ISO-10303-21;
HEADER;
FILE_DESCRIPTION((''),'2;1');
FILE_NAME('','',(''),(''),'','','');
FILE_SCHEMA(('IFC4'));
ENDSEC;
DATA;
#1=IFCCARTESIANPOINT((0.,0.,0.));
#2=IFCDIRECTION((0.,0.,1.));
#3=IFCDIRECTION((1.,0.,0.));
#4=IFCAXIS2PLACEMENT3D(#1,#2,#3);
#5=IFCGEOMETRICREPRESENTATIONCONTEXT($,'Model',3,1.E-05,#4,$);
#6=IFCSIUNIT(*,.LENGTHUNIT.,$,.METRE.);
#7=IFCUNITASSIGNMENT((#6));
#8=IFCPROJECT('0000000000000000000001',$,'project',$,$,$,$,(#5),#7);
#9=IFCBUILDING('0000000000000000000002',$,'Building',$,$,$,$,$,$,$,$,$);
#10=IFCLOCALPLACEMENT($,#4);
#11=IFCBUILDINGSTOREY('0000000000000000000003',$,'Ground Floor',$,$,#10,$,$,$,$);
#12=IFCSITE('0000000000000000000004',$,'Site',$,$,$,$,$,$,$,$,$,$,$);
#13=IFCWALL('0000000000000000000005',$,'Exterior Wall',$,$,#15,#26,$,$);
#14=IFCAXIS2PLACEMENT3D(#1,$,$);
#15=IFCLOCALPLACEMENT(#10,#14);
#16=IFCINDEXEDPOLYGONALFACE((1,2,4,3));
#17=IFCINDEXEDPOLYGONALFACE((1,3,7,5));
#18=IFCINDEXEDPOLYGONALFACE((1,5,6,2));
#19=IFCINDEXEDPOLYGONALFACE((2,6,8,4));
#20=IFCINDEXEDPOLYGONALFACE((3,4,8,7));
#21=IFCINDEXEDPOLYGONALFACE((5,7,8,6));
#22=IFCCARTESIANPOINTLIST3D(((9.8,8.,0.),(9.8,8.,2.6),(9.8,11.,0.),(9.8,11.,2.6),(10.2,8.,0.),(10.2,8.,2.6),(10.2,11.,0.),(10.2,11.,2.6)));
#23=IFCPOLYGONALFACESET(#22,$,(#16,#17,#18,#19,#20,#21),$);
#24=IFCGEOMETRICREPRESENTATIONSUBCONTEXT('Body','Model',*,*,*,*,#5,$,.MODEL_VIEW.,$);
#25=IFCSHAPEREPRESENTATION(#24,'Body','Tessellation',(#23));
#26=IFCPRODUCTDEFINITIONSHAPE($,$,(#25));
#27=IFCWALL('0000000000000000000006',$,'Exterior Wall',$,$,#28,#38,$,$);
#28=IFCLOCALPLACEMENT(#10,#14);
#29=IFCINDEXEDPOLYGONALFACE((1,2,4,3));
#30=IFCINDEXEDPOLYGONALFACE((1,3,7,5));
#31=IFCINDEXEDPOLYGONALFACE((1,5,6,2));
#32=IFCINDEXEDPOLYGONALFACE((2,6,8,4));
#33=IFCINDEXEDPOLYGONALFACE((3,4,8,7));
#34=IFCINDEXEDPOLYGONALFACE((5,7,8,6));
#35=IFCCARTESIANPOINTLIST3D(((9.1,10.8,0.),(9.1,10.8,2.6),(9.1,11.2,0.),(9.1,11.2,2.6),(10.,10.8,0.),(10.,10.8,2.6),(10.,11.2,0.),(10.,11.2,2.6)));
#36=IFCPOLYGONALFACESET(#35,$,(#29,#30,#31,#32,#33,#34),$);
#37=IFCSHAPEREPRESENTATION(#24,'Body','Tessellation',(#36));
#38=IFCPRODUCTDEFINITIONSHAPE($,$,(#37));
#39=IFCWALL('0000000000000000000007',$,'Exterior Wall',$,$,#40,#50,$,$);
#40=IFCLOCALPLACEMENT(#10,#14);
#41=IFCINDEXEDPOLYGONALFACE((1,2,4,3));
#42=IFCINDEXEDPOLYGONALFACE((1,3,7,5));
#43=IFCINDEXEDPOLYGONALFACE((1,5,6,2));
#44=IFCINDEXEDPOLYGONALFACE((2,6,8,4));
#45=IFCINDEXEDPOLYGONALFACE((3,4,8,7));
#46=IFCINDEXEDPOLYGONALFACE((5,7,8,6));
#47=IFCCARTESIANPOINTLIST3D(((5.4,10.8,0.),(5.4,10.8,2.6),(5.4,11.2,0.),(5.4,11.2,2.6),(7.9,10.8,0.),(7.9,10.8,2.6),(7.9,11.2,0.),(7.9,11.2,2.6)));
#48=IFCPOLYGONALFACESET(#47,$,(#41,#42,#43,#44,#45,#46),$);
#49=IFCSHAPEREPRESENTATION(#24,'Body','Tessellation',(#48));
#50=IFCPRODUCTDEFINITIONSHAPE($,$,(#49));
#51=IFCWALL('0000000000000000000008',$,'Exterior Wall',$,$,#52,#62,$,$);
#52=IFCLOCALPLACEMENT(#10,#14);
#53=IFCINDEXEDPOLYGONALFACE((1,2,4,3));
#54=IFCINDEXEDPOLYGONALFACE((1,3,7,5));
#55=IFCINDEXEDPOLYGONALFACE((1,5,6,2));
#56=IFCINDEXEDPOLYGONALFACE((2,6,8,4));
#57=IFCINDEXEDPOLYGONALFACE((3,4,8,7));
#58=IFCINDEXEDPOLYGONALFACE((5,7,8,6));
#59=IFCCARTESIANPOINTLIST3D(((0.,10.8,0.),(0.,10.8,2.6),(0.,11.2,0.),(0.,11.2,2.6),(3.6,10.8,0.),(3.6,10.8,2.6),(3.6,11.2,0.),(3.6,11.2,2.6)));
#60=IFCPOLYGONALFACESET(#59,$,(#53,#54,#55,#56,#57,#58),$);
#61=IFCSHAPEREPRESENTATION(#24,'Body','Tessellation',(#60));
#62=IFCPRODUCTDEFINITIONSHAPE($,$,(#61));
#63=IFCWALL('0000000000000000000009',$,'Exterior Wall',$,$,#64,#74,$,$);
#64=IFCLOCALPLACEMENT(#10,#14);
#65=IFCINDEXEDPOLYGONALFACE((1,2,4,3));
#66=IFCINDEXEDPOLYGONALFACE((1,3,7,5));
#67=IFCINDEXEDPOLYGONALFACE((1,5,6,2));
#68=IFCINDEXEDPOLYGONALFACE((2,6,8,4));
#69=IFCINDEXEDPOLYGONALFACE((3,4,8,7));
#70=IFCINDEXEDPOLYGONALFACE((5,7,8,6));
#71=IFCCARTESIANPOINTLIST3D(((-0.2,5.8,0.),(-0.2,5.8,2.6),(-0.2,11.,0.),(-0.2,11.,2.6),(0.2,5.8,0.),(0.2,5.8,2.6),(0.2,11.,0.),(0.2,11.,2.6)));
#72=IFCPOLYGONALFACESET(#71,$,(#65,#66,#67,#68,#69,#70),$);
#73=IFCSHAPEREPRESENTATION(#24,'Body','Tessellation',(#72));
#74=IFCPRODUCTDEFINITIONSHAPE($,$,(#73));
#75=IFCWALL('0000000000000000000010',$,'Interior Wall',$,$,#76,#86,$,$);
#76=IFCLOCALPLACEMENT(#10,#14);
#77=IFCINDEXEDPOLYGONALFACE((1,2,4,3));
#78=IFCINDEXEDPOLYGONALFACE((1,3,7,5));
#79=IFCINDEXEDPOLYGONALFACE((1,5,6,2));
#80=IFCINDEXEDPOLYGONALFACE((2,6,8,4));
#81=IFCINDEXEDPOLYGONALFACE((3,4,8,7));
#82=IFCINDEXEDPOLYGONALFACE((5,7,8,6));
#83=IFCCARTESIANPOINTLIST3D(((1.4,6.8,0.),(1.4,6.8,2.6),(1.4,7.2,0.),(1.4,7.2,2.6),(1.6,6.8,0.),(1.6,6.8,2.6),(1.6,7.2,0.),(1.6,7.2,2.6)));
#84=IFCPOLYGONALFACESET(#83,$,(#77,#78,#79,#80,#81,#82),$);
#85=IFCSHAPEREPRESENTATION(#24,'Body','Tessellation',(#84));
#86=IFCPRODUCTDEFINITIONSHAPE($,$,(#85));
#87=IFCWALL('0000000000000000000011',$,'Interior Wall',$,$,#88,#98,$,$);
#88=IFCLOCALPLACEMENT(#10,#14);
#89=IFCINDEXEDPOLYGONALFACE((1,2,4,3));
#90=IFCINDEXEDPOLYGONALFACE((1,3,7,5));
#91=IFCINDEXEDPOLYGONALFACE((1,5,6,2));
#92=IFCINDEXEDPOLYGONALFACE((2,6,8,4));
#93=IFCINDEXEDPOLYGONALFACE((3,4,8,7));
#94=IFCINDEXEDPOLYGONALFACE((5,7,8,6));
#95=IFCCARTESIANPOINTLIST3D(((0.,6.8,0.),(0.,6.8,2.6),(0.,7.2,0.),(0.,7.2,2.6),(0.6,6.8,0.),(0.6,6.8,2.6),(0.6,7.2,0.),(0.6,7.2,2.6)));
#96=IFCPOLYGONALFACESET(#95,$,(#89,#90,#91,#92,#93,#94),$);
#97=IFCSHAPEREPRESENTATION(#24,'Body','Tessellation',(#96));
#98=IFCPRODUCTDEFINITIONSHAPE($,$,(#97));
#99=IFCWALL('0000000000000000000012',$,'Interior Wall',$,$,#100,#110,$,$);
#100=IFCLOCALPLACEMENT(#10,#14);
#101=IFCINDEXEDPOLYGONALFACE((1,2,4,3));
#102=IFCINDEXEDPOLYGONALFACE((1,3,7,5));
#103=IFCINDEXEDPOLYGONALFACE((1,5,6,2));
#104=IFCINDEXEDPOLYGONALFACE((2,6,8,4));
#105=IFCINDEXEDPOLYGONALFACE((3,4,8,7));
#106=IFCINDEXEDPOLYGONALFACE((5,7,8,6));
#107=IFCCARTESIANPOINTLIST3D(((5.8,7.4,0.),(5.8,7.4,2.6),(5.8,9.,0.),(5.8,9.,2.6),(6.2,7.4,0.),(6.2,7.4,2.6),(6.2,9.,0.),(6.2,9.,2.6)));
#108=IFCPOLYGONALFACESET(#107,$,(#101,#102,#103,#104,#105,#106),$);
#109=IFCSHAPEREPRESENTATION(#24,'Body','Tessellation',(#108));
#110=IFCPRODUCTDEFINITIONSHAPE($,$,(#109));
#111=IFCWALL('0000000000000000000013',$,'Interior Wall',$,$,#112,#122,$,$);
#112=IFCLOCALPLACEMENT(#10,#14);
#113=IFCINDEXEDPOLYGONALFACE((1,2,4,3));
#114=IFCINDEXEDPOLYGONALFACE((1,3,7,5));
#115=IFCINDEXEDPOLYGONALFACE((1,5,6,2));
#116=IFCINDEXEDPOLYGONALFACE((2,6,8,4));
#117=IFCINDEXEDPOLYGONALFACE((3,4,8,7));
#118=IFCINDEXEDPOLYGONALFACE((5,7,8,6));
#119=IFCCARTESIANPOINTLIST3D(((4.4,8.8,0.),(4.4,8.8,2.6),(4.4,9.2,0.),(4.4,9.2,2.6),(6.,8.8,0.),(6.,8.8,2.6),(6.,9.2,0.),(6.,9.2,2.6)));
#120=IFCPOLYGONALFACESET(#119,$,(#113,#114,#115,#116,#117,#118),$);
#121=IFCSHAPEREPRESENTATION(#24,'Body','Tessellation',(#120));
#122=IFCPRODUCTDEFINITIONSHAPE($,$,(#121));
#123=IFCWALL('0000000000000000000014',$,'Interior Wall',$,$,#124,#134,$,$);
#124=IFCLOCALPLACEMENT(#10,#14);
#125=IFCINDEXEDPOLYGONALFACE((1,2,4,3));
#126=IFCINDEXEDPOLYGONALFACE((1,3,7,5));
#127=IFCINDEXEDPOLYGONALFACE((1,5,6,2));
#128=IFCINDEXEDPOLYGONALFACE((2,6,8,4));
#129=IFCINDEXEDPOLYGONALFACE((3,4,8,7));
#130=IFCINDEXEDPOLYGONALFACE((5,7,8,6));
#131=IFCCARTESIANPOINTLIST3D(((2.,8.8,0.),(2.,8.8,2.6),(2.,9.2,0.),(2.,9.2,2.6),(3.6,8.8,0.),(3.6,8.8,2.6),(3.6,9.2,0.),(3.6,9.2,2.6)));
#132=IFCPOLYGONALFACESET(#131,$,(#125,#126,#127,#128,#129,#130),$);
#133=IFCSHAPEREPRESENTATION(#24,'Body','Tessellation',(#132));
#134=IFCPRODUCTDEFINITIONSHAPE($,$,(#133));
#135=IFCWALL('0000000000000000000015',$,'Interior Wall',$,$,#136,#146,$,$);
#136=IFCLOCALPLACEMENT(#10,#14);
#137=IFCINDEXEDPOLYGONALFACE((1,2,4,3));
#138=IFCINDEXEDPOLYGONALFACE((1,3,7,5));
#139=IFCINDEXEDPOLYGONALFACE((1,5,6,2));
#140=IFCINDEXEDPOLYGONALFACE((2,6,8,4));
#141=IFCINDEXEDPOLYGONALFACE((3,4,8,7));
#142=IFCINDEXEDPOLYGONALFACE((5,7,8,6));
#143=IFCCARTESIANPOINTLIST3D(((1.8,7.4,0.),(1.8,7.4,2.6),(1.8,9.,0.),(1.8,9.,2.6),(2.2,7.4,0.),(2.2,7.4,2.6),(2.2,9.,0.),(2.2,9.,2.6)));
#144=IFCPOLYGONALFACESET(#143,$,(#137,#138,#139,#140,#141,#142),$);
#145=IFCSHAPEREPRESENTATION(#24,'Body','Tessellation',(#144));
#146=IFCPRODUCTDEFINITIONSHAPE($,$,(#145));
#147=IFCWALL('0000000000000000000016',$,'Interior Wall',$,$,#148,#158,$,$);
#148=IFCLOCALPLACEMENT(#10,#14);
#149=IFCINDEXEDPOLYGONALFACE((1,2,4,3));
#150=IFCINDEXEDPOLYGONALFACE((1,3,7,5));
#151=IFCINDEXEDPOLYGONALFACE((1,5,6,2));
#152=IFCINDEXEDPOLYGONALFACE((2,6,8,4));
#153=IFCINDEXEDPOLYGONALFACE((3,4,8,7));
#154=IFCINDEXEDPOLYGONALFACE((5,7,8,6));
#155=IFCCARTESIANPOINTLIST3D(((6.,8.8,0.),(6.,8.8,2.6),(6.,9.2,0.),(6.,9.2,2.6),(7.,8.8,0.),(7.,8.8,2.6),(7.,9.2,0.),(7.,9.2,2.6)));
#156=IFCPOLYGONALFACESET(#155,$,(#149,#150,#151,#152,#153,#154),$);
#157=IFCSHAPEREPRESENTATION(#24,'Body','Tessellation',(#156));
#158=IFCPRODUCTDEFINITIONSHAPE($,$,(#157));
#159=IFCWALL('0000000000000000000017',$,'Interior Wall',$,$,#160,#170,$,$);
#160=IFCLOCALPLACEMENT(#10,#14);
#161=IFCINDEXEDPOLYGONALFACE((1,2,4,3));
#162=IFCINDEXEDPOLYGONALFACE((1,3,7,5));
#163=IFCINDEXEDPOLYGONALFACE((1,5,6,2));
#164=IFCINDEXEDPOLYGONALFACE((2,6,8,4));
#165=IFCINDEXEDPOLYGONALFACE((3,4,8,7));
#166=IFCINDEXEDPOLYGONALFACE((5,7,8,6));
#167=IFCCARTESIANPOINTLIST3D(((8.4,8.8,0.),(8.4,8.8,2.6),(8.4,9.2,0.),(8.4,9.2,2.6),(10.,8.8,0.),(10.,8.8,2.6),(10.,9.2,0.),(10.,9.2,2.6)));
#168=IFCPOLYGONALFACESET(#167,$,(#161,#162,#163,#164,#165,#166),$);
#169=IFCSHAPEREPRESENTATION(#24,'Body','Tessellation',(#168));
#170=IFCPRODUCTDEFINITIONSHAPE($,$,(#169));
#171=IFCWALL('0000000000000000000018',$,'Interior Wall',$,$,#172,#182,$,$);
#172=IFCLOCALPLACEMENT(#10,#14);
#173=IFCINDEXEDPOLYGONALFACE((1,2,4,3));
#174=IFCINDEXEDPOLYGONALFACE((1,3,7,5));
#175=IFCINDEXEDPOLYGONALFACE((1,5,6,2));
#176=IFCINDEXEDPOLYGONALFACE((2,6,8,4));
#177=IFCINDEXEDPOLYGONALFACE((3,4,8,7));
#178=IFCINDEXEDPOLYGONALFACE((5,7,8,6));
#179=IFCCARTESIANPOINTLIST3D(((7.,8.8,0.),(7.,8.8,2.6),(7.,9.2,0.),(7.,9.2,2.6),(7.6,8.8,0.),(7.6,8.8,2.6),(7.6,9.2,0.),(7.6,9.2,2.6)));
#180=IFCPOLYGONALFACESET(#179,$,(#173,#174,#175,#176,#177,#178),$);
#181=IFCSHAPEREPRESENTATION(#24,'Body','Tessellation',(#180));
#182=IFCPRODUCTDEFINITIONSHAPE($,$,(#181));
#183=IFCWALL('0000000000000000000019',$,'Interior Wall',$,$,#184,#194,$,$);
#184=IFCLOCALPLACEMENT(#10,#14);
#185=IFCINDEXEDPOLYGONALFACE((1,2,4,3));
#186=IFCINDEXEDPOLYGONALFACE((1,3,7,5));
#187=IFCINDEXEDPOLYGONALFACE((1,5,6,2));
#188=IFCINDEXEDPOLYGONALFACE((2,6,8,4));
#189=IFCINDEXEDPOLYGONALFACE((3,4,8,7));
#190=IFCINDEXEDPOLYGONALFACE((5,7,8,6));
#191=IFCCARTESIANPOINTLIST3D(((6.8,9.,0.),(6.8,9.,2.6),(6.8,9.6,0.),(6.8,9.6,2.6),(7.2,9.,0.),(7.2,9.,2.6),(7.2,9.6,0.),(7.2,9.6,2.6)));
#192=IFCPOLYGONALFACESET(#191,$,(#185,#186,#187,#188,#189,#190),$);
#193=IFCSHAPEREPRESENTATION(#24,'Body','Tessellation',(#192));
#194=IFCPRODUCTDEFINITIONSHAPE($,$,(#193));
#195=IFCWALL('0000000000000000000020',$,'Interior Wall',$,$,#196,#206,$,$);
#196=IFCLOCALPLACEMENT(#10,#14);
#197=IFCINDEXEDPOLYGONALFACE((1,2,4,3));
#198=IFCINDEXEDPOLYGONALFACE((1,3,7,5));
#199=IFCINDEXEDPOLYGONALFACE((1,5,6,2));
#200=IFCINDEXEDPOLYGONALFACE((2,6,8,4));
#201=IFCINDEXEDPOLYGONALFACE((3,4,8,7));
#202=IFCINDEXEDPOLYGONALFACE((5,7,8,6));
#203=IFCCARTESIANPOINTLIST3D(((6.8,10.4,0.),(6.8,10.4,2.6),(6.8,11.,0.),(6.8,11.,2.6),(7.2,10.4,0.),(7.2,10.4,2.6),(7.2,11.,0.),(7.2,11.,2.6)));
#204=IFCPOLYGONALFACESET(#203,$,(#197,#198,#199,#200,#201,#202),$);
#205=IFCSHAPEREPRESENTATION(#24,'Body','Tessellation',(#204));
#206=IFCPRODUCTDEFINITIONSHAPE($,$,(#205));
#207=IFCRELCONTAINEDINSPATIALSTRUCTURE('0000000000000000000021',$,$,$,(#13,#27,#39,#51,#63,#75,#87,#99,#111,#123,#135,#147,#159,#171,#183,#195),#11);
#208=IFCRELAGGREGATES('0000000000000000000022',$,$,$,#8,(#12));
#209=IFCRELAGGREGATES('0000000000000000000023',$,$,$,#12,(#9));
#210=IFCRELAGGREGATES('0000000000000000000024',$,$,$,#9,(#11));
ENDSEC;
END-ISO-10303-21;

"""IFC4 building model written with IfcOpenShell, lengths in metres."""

from ifc_helpers import new_model, si_unit, frame, origin_with_axes, place, context, subcontext, project, spatial, indexed_curve, outline, extrude, element, save


model = new_model("IFC4")

# Units and contexts
model_context = context("Model", 3, precision=1e-05, world=origin_with_axes())
body_context = subcontext(model_context, "Body", "Model", "MODEL_VIEW")
ifc_project = project(units=[si_unit("LENGTHUNIT", "METRE")], contexts=[model_context])

# Site, building, storey
site = spatial("IfcSite", under=ifc_project, Name="Site")
building = spatial("IfcBuilding", under=site, Name="Building")
storey_placement = place(None, origin_with_axes())
storey = spatial("IfcBuildingStorey", under=building, at=storey_placement, Name="Ground Floor")

# Walls
wall_1_placement = place(storey_placement, frame((10.0, 8.0, 0.0), z_axis=(0.0, 0.0, 1.0), x_axis=(0.0, 1.0, 0.0)))
element("IfcWall", 1, at=wall_1_placement, inside=storey, Name="Exterior Wall", context=body_context, shape_type="SweptSolid", body=[
    extrude(outline(indexed_curve([(0.0, 0.0), (0.0, 0.4), (3.0, 0.4), (3.0, 0.0), (0.0, 0.0)], self_intersect=False)), frame((0.0, -0.2, 0.0), z_axis=(0.0, 0.0, 1.0), x_axis=(1.0, 0.0, 0.0)), (0.0, 0.0, 1.0), 2.6),
])
wall_2_placement = place(storey_placement, frame((10.0, 11.0, 0.0), z_axis=(0.0, 0.0, 1.0), x_axis=(-1.0, 0.0, 0.0)))
element("IfcWall", 2, at=wall_2_placement, inside=storey, Name="Exterior Wall", context=body_context, shape_type="SweptSolid", body=[
    extrude(outline(indexed_curve([(0.0, 0.0), (0.0, 0.4), (0.9, 0.4), (0.9, 0.0), (0.0, 0.0)], self_intersect=False)), frame((0.0, -0.2, 0.0), z_axis=(0.0, 0.0, 1.0), x_axis=(1.0, 0.0, 0.0)), (0.0, 0.0, 1.0), 2.6),
])
wall_3_placement = place(storey_placement, frame((7.9, 11.0, 0.0), z_axis=(0.0, 0.0, 1.0), x_axis=(-1.0, 0.0, 0.0)))
element("IfcWall", 3, at=wall_3_placement, inside=storey, Name="Exterior Wall", context=body_context, shape_type="SweptSolid", body=[
    extrude(outline(indexed_curve([(0.0, 0.0), (0.0, 0.4), (2.5, 0.4), (2.5, 0.0), (0.0, 0.0)], self_intersect=False)), frame((0.0, -0.2, 0.0), z_axis=(0.0, 0.0, 1.0), x_axis=(1.0, 0.0, 0.0)), (0.0, 0.0, 1.0), 2.6),
])
wall_4_placement = place(storey_placement, frame((3.6, 11.0, 0.0), z_axis=(0.0, 0.0, 1.0), x_axis=(-1.0, 0.0, 0.0)))
element("IfcWall", 4, at=wall_4_placement, inside=storey, Name="Exterior Wall", context=body_context, shape_type="SweptSolid", body=[
    extrude(outline(indexed_curve([(0.0, 0.0), (0.0, 0.4), (3.6, 0.4), (3.6, 0.0), (0.0, 0.0)], self_intersect=False)), frame((0.0, -0.2, 0.0), z_axis=(0.0, 0.0, 1.0), x_axis=(1.0, 0.0, 0.0)), (0.0, 0.0, 1.0), 2.6),
])
wall_5_placement = place(storey_placement, frame((0.0, 11.0, 0.0), z_axis=(0.0, 0.0, 1.0), x_axis=(0.0, -1.0, 0.0)))
element("IfcWall", 5, at=wall_5_placement, inside=storey, Name="Exterior Wall", context=body_context, shape_type="SweptSolid", body=[
    extrude(outline(indexed_curve([(0.0, 0.0), (0.0, 0.4), (5.2, 0.4), (5.2, 0.0), (0.0, 0.0)], self_intersect=False)), frame((0.0, -0.2, 0.0), z_axis=(0.0, 0.0, 1.0), x_axis=(1.0, 0.0, 0.0)), (0.0, 0.0, 1.0), 2.6),
])
wall_6_placement = place(storey_placement, frame((1.6, 7.0, 0.0), z_axis=(0.0, 0.0, 1.0), x_axis=(-1.0, 0.0, 0.0)))
element("IfcWall", 6, at=wall_6_placement, inside=storey, Name="Interior Wall", context=body_context, shape_type="SweptSolid", body=[
    extrude(outline(indexed_curve([(0.0, 0.0), (0.0, 0.4), (0.2, 0.4), (0.2, 0.0), (0.0, 0.0)], self_intersect=False)), frame((0.0, -0.2, 0.0), z_axis=(0.0, 0.0, 1.0), x_axis=(1.0, 0.0, 0.0)), (0.0, 0.0, 1.0), 2.6),
])
wall_7_placement = place(storey_placement, frame((0.6, 7.0, 0.0), z_axis=(0.0, 0.0, 1.0), x_axis=(-1.0, 0.0, 0.0)))
element("IfcWall", 7, at=wall_7_placement, inside=storey, Name="Interior Wall", context=body_context, shape_type="SweptSolid", body=[
    extrude(outline(indexed_curve([(0.0, 0.0), (0.0, 0.4), (0.6, 0.4), (0.6, 0.0), (0.0, 0.0)], self_intersect=False)), frame((0.0, -0.2, 0.0), z_axis=(0.0, 0.0, 1.0), x_axis=(1.0, 0.0, 0.0)), (0.0, 0.0, 1.0), 2.6),
])
for number, where, z_axis, x_axis, name in (
    (8, (6.0, 7.4, 0.0), (0.0, 0.0, 1.0), (0.0, 1.0, 0.0), "Interior Wall"),
    (9, (6.0, 9.0, 0.0), (0.0, 0.0, 1.0), (-1.0, 0.0, 0.0), "Interior Wall"),
):
    element("IfcWall", number, at=place(storey_placement, frame(where, z_axis=z_axis, x_axis=x_axis)), inside=storey, Name=name, context=body_context, shape_type="SweptSolid", body=[
        extrude(outline(indexed_curve([(0.0, 0.0), (0.0, 0.4), (1.6, 0.4), (1.6, 0.0), (0.0, 0.0)], self_intersect=False)), frame((0.0, -0.2, 0.0), z_axis=(0.0, 0.0, 1.0), x_axis=(1.0, 0.0, 0.0)), (0.0, 0.0, 1.0), 2.6),
    ])
wall_8_placement = place(storey_placement, frame((3.6, 9.0, 0.0), z_axis=(0.0, 0.0, 1.0), x_axis=(-1.0, 0.0, 0.0)))
element("IfcWall", 10, at=wall_8_placement, inside=storey, Name="Interior Wall", context=body_context, shape_type="SweptSolid", body=[
    extrude(outline(indexed_curve([(0.0, 0.0), (0.0, 0.4), (1.6, 0.4), (1.6, 0.0), (0.0, 0.0)], self_intersect=False)), frame((0.0, -0.2, 0.0), z_axis=(0.0, 0.0, 1.0), x_axis=(1.0, 0.0, 0.0)), (0.0, 0.0, 1.0), 2.6),
])
wall_9_placement = place(storey_placement, frame((2.0, 9.0, 0.0), z_axis=(0.0, 0.0, 1.0), x_axis=(0.0, -1.0, 0.0)))
element("IfcWall", 11, at=wall_9_placement, inside=storey, Name="Interior Wall", context=body_context, shape_type="SweptSolid", body=[
    extrude(outline(indexed_curve([(0.0, 0.0), (0.0, 0.4), (1.6, 0.4), (1.6, 0.0), (0.0, 0.0)], self_intersect=False)), frame((0.0, -0.2, 0.0), z_axis=(0.0, 0.0, 1.0), x_axis=(1.0, 0.0, 0.0)), (0.0, 0.0, 1.0), 2.6),
])
wall_10_placement = place(storey_placement, frame((7.0, 9.0, 0.0), z_axis=(0.0, 0.0, 1.0), x_axis=(-1.0, 0.0, 0.0)))
element("IfcWall", 12, at=wall_10_placement, inside=storey, Name="Interior Wall", context=body_context, shape_type="SweptSolid", body=[
    extrude(outline(indexed_curve([(0.0, 0.0), (0.0, 0.4), (1.0, 0.4), (1.0, 0.0), (0.0, 0.0)], self_intersect=False)), frame((0.0, -0.2, 0.0), z_axis=(0.0, 0.0, 1.0), x_axis=(1.0, 0.0, 0.0)), (0.0, 0.0, 1.0), 2.6),
])
wall_11_placement = place(storey_placement, frame((10.0, 9.0, 0.0), z_axis=(0.0, 0.0, 1.0), x_axis=(-1.0, 0.0, 0.0)))
element("IfcWall", 13, at=wall_11_placement, inside=storey, Name="Interior Wall", context=body_context, shape_type="SweptSolid", body=[
    extrude(outline(indexed_curve([(0.0, 0.0), (0.0, 0.4), (1.6, 0.4), (1.6, 0.0), (0.0, 0.0)], self_intersect=False)), frame((0.0, -0.2, 0.0), z_axis=(0.0, 0.0, 1.0), x_axis=(1.0, 0.0, 0.0)), (0.0, 0.0, 1.0), 2.6),
])
for number, where, z_axis, x_axis, name in (
    (14, (7.6, 9.0, 0.0), (0.0, 0.0, 1.0), (-1.0, 0.0, 0.0), "Interior Wall"),
    (15, (7.0, 9.0, 0.0), (0.0, 0.0, 1.0), (0.0, 1.0, 0.0), "Interior Wall"),
    (16, (7.0, 10.4, 0.0), (0.0, 0.0, 1.0), (0.0, 1.0, 0.0), "Interior Wall"),
):
    element("IfcWall", number, at=place(storey_placement, frame(where, z_axis=z_axis, x_axis=x_axis)), inside=storey, Name=name, context=body_context, shape_type="SweptSolid", body=[
        extrude(outline(indexed_curve([(0.0, 0.0), (0.0, 0.4), (0.6, 0.4), (0.6, 0.0), (0.0, 0.0)], self_intersect=False)), frame((0.0, -0.2, 0.0), z_axis=(0.0, 0.0, 1.0), x_axis=(1.0, 0.0, 0.0)), (0.0, 0.0, 1.0), 2.6),
    ])

save(model, "model.ifc")
